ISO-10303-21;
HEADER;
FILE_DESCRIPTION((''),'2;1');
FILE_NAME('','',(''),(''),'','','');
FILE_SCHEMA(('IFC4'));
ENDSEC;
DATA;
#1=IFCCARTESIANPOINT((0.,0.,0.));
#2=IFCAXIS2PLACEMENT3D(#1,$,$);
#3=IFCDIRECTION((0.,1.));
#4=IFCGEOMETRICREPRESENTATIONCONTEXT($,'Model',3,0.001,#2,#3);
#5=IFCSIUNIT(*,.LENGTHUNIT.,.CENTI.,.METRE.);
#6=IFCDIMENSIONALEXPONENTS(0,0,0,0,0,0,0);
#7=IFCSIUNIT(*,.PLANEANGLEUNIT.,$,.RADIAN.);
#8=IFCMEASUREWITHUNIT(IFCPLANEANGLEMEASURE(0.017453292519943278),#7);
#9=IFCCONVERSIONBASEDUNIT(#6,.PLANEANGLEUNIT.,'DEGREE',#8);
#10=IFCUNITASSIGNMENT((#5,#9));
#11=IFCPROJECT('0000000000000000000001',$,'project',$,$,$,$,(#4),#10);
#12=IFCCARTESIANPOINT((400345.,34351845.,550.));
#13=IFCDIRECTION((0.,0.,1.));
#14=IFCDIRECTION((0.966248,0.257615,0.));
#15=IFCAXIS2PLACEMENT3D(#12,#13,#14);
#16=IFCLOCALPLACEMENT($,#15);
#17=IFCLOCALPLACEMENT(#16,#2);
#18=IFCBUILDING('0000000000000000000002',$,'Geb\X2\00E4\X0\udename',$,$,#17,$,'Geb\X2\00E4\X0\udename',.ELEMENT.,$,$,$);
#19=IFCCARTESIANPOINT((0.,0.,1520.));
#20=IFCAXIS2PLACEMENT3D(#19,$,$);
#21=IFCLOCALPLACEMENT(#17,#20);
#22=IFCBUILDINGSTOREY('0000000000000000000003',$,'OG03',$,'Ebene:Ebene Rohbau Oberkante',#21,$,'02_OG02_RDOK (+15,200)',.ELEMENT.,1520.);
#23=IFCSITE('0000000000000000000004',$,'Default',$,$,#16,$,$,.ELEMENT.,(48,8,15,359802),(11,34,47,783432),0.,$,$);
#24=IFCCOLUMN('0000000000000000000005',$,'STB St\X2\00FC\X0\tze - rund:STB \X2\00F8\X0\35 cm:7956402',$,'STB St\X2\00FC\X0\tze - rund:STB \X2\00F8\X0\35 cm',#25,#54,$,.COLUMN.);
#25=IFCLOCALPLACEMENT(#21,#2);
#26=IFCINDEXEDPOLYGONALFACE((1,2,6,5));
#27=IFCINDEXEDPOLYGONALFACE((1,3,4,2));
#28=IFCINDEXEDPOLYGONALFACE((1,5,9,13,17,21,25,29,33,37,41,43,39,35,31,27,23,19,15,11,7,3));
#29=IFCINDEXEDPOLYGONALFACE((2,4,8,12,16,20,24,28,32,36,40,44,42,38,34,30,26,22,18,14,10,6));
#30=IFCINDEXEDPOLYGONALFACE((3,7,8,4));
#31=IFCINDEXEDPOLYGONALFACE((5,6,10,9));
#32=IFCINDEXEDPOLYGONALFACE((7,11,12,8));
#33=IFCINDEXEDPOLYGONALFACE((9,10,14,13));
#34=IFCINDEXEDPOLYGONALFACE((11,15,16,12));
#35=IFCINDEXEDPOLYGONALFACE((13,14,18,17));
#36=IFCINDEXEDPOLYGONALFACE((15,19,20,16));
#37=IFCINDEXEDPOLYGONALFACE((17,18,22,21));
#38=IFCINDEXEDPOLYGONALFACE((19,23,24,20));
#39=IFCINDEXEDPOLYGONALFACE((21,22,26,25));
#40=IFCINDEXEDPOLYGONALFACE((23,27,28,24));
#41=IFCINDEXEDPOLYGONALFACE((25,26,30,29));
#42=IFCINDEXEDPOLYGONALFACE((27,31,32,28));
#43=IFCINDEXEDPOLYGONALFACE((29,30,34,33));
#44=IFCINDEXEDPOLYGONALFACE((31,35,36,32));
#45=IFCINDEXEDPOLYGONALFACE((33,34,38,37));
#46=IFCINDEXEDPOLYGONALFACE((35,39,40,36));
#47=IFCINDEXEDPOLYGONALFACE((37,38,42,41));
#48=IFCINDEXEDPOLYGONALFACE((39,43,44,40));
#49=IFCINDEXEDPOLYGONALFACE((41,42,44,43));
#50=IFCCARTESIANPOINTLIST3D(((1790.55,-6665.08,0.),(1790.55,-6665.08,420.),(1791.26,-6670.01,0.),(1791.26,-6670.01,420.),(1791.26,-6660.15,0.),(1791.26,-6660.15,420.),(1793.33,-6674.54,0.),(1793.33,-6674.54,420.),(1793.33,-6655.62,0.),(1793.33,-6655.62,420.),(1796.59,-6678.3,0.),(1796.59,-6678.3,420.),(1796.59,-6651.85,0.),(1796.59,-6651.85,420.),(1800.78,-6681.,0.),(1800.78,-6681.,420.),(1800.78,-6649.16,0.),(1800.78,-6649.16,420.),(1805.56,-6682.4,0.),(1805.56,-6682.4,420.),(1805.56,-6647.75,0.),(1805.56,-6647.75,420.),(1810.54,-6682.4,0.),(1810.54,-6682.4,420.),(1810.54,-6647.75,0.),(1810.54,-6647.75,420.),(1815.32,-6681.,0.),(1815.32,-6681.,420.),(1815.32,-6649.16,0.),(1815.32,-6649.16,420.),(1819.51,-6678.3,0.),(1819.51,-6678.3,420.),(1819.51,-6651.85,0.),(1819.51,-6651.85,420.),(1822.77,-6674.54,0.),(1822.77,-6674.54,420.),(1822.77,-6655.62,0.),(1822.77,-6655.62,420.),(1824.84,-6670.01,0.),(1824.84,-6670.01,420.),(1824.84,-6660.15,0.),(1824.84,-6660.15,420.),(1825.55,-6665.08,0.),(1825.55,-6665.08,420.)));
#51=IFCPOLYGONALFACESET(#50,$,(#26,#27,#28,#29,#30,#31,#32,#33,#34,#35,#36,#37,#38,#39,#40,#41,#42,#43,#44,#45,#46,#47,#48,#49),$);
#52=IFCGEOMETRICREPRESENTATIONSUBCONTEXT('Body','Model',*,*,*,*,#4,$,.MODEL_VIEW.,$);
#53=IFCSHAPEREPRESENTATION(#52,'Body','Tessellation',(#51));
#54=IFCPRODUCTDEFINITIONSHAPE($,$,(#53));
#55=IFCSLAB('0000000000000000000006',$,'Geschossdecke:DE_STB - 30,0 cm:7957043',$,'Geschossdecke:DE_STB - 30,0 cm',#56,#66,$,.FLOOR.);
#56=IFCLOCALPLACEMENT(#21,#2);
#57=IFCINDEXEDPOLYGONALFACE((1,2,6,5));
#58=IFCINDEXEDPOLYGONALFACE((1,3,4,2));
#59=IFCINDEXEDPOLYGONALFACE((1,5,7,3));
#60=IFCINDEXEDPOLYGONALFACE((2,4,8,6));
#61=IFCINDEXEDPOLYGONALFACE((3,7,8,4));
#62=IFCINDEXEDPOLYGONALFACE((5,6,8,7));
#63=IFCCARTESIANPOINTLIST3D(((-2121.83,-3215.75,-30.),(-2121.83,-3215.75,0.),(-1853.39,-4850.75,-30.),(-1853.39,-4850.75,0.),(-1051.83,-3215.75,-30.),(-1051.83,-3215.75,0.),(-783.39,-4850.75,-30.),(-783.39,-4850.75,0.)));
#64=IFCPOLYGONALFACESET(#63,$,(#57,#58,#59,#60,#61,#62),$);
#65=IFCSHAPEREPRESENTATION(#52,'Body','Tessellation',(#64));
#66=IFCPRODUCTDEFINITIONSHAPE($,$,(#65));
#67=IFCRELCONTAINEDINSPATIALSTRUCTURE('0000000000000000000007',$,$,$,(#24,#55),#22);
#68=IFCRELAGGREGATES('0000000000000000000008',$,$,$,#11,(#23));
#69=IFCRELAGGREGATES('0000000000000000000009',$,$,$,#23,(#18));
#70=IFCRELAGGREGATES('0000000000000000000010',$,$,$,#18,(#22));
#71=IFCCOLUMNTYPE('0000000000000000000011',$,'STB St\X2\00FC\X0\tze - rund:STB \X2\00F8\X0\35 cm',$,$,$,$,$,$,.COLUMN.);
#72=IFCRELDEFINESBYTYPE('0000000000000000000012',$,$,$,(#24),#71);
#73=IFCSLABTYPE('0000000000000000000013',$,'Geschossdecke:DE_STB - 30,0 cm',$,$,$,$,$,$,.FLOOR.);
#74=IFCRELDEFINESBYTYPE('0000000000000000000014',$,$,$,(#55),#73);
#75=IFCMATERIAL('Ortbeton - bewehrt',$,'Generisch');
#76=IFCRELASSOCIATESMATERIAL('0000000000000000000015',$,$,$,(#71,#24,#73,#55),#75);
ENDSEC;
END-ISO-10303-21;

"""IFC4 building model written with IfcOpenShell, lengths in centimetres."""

from ifc_helpers import new_model, entity, si_unit, converted_unit, direction, frame, origin, place, context, subcontext, project, spatial, arc, indexed_curve, outline, extrude, source, transform, mapped, material, type_object, type_shapes, element, save


model = new_model("IFC4")

# Units and contexts
model_context = context("Model", 3, precision=0.001, world=origin(), true_north=direction((0.0, 1.0)))
body_context = subcontext(model_context, "Body", "Model", "MODEL_VIEW")
ifc_project = project(units=[si_unit("LENGTHUNIT", "METRE", prefix="CENTI"), converted_unit("PLANEANGLEUNIT", "DEGREE", entity("IfcPlaneAngleMeasure", 0.017453292519943278), si_unit("PLANEANGLEUNIT", "RADIAN"), dimensions=[0, 0, 0, 0, 0, 0, 0])], contexts=[model_context])

# Site, building, storey
site_placement = place(None, frame((400345.0, 34351845.0, 550.0), z_axis=(0.0, 0.0, 1.0), x_axis=(0.966248, 0.257615, 0.0)))
site = spatial("IfcSite", under=ifc_project, at=site_placement, Name="Default", CompositionType="ELEMENT", RefLatitude=(48, 8, 15, 359802), RefLongitude=(11, 34, 47, 783432), RefElevation=0.0)
building_placement = place(site_placement, origin())
building = spatial("IfcBuilding", under=site, at=building_placement, Name="Gebäudename", LongName="Gebäudename", CompositionType="ELEMENT")
storey_placement = place(building_placement, frame((0.0, 0.0, 1520.0)))
storey = spatial("IfcBuildingStorey", under=building, at=storey_placement, Name="OG03", ObjectType="Ebene:Ebene Rohbau Oberkante", LongName="02_OG02_RDOK (+15,200)", CompositionType="ELEMENT", Elevation=1520.0)

# Column
ifc_material = material(Name="Ortbeton - bewehrt", Category="Generisch")
column_type_1 = type_object("IfcColumnType", Name="STB Stütze - rund:STB ø35 cm", PredefinedType="COLUMN", material=ifc_material)
shared_shape_1 = source(origin(), body_context, "Body", "SweptSolid", [
    extrude(outline(indexed_curve([(-17.5, 0.0), (0.0, -17.5), (17.5, 0.0), (0.0, 17.5)], segments=[arc(1, 2, 3), arc(3, 4, 1)], self_intersect=False)), frame((1808.05, -6665.08, 1520.0)), (0.0, 0.0, 1.0), 420.0),
])
type_shapes(column_type_1, [shared_shape_1])
column_1_placement = place(storey_placement, frame((0.0, 0.0, -1520.0)))
element("IfcColumn", 1, at=column_1_placement, inside=storey, type_object=column_type_1, material=ifc_material, Name="STB Stütze - rund:STB ø35 cm:7956402", ObjectType="STB Stütze - rund:STB ø35 cm", PredefinedType="COLUMN", context=body_context, shape_type="MappedRepresentation", body=[
    mapped(shared_shape_1, transform((0.0, 0.0, 0.0), scale=1.0)),
])

# Slab
slab_type = type_object("IfcSlabType", Name="Geschossdecke:DE_STB - 30,0 cm", PredefinedType="FLOOR", material=ifc_material)
slab_placement = place(storey_placement, origin())
element("IfcSlab", 2, at=slab_placement, inside=storey, type_object=slab_type, material=ifc_material, Name="Geschossdecke:DE_STB - 30,0 cm:7957043", ObjectType="Geschossdecke:DE_STB - 30,0 cm", PredefinedType="FLOOR", context=body_context, shape_type="SweptSolid", body=[
    extrude(outline(indexed_curve([(-669.22, -817.5), (400.78, -817.5), (669.22, 817.5), (-400.78, 817.5), (-669.22, -817.5)], self_intersect=False)), frame((-1452.61, -4033.25, 0.0), z_axis=(0.0, 0.0, -1.0), x_axis=(-1.0, 0.0, 0.0)), (0.0, 0.0, 1.0), 30.0),
])

save(model, "model.ifc")
